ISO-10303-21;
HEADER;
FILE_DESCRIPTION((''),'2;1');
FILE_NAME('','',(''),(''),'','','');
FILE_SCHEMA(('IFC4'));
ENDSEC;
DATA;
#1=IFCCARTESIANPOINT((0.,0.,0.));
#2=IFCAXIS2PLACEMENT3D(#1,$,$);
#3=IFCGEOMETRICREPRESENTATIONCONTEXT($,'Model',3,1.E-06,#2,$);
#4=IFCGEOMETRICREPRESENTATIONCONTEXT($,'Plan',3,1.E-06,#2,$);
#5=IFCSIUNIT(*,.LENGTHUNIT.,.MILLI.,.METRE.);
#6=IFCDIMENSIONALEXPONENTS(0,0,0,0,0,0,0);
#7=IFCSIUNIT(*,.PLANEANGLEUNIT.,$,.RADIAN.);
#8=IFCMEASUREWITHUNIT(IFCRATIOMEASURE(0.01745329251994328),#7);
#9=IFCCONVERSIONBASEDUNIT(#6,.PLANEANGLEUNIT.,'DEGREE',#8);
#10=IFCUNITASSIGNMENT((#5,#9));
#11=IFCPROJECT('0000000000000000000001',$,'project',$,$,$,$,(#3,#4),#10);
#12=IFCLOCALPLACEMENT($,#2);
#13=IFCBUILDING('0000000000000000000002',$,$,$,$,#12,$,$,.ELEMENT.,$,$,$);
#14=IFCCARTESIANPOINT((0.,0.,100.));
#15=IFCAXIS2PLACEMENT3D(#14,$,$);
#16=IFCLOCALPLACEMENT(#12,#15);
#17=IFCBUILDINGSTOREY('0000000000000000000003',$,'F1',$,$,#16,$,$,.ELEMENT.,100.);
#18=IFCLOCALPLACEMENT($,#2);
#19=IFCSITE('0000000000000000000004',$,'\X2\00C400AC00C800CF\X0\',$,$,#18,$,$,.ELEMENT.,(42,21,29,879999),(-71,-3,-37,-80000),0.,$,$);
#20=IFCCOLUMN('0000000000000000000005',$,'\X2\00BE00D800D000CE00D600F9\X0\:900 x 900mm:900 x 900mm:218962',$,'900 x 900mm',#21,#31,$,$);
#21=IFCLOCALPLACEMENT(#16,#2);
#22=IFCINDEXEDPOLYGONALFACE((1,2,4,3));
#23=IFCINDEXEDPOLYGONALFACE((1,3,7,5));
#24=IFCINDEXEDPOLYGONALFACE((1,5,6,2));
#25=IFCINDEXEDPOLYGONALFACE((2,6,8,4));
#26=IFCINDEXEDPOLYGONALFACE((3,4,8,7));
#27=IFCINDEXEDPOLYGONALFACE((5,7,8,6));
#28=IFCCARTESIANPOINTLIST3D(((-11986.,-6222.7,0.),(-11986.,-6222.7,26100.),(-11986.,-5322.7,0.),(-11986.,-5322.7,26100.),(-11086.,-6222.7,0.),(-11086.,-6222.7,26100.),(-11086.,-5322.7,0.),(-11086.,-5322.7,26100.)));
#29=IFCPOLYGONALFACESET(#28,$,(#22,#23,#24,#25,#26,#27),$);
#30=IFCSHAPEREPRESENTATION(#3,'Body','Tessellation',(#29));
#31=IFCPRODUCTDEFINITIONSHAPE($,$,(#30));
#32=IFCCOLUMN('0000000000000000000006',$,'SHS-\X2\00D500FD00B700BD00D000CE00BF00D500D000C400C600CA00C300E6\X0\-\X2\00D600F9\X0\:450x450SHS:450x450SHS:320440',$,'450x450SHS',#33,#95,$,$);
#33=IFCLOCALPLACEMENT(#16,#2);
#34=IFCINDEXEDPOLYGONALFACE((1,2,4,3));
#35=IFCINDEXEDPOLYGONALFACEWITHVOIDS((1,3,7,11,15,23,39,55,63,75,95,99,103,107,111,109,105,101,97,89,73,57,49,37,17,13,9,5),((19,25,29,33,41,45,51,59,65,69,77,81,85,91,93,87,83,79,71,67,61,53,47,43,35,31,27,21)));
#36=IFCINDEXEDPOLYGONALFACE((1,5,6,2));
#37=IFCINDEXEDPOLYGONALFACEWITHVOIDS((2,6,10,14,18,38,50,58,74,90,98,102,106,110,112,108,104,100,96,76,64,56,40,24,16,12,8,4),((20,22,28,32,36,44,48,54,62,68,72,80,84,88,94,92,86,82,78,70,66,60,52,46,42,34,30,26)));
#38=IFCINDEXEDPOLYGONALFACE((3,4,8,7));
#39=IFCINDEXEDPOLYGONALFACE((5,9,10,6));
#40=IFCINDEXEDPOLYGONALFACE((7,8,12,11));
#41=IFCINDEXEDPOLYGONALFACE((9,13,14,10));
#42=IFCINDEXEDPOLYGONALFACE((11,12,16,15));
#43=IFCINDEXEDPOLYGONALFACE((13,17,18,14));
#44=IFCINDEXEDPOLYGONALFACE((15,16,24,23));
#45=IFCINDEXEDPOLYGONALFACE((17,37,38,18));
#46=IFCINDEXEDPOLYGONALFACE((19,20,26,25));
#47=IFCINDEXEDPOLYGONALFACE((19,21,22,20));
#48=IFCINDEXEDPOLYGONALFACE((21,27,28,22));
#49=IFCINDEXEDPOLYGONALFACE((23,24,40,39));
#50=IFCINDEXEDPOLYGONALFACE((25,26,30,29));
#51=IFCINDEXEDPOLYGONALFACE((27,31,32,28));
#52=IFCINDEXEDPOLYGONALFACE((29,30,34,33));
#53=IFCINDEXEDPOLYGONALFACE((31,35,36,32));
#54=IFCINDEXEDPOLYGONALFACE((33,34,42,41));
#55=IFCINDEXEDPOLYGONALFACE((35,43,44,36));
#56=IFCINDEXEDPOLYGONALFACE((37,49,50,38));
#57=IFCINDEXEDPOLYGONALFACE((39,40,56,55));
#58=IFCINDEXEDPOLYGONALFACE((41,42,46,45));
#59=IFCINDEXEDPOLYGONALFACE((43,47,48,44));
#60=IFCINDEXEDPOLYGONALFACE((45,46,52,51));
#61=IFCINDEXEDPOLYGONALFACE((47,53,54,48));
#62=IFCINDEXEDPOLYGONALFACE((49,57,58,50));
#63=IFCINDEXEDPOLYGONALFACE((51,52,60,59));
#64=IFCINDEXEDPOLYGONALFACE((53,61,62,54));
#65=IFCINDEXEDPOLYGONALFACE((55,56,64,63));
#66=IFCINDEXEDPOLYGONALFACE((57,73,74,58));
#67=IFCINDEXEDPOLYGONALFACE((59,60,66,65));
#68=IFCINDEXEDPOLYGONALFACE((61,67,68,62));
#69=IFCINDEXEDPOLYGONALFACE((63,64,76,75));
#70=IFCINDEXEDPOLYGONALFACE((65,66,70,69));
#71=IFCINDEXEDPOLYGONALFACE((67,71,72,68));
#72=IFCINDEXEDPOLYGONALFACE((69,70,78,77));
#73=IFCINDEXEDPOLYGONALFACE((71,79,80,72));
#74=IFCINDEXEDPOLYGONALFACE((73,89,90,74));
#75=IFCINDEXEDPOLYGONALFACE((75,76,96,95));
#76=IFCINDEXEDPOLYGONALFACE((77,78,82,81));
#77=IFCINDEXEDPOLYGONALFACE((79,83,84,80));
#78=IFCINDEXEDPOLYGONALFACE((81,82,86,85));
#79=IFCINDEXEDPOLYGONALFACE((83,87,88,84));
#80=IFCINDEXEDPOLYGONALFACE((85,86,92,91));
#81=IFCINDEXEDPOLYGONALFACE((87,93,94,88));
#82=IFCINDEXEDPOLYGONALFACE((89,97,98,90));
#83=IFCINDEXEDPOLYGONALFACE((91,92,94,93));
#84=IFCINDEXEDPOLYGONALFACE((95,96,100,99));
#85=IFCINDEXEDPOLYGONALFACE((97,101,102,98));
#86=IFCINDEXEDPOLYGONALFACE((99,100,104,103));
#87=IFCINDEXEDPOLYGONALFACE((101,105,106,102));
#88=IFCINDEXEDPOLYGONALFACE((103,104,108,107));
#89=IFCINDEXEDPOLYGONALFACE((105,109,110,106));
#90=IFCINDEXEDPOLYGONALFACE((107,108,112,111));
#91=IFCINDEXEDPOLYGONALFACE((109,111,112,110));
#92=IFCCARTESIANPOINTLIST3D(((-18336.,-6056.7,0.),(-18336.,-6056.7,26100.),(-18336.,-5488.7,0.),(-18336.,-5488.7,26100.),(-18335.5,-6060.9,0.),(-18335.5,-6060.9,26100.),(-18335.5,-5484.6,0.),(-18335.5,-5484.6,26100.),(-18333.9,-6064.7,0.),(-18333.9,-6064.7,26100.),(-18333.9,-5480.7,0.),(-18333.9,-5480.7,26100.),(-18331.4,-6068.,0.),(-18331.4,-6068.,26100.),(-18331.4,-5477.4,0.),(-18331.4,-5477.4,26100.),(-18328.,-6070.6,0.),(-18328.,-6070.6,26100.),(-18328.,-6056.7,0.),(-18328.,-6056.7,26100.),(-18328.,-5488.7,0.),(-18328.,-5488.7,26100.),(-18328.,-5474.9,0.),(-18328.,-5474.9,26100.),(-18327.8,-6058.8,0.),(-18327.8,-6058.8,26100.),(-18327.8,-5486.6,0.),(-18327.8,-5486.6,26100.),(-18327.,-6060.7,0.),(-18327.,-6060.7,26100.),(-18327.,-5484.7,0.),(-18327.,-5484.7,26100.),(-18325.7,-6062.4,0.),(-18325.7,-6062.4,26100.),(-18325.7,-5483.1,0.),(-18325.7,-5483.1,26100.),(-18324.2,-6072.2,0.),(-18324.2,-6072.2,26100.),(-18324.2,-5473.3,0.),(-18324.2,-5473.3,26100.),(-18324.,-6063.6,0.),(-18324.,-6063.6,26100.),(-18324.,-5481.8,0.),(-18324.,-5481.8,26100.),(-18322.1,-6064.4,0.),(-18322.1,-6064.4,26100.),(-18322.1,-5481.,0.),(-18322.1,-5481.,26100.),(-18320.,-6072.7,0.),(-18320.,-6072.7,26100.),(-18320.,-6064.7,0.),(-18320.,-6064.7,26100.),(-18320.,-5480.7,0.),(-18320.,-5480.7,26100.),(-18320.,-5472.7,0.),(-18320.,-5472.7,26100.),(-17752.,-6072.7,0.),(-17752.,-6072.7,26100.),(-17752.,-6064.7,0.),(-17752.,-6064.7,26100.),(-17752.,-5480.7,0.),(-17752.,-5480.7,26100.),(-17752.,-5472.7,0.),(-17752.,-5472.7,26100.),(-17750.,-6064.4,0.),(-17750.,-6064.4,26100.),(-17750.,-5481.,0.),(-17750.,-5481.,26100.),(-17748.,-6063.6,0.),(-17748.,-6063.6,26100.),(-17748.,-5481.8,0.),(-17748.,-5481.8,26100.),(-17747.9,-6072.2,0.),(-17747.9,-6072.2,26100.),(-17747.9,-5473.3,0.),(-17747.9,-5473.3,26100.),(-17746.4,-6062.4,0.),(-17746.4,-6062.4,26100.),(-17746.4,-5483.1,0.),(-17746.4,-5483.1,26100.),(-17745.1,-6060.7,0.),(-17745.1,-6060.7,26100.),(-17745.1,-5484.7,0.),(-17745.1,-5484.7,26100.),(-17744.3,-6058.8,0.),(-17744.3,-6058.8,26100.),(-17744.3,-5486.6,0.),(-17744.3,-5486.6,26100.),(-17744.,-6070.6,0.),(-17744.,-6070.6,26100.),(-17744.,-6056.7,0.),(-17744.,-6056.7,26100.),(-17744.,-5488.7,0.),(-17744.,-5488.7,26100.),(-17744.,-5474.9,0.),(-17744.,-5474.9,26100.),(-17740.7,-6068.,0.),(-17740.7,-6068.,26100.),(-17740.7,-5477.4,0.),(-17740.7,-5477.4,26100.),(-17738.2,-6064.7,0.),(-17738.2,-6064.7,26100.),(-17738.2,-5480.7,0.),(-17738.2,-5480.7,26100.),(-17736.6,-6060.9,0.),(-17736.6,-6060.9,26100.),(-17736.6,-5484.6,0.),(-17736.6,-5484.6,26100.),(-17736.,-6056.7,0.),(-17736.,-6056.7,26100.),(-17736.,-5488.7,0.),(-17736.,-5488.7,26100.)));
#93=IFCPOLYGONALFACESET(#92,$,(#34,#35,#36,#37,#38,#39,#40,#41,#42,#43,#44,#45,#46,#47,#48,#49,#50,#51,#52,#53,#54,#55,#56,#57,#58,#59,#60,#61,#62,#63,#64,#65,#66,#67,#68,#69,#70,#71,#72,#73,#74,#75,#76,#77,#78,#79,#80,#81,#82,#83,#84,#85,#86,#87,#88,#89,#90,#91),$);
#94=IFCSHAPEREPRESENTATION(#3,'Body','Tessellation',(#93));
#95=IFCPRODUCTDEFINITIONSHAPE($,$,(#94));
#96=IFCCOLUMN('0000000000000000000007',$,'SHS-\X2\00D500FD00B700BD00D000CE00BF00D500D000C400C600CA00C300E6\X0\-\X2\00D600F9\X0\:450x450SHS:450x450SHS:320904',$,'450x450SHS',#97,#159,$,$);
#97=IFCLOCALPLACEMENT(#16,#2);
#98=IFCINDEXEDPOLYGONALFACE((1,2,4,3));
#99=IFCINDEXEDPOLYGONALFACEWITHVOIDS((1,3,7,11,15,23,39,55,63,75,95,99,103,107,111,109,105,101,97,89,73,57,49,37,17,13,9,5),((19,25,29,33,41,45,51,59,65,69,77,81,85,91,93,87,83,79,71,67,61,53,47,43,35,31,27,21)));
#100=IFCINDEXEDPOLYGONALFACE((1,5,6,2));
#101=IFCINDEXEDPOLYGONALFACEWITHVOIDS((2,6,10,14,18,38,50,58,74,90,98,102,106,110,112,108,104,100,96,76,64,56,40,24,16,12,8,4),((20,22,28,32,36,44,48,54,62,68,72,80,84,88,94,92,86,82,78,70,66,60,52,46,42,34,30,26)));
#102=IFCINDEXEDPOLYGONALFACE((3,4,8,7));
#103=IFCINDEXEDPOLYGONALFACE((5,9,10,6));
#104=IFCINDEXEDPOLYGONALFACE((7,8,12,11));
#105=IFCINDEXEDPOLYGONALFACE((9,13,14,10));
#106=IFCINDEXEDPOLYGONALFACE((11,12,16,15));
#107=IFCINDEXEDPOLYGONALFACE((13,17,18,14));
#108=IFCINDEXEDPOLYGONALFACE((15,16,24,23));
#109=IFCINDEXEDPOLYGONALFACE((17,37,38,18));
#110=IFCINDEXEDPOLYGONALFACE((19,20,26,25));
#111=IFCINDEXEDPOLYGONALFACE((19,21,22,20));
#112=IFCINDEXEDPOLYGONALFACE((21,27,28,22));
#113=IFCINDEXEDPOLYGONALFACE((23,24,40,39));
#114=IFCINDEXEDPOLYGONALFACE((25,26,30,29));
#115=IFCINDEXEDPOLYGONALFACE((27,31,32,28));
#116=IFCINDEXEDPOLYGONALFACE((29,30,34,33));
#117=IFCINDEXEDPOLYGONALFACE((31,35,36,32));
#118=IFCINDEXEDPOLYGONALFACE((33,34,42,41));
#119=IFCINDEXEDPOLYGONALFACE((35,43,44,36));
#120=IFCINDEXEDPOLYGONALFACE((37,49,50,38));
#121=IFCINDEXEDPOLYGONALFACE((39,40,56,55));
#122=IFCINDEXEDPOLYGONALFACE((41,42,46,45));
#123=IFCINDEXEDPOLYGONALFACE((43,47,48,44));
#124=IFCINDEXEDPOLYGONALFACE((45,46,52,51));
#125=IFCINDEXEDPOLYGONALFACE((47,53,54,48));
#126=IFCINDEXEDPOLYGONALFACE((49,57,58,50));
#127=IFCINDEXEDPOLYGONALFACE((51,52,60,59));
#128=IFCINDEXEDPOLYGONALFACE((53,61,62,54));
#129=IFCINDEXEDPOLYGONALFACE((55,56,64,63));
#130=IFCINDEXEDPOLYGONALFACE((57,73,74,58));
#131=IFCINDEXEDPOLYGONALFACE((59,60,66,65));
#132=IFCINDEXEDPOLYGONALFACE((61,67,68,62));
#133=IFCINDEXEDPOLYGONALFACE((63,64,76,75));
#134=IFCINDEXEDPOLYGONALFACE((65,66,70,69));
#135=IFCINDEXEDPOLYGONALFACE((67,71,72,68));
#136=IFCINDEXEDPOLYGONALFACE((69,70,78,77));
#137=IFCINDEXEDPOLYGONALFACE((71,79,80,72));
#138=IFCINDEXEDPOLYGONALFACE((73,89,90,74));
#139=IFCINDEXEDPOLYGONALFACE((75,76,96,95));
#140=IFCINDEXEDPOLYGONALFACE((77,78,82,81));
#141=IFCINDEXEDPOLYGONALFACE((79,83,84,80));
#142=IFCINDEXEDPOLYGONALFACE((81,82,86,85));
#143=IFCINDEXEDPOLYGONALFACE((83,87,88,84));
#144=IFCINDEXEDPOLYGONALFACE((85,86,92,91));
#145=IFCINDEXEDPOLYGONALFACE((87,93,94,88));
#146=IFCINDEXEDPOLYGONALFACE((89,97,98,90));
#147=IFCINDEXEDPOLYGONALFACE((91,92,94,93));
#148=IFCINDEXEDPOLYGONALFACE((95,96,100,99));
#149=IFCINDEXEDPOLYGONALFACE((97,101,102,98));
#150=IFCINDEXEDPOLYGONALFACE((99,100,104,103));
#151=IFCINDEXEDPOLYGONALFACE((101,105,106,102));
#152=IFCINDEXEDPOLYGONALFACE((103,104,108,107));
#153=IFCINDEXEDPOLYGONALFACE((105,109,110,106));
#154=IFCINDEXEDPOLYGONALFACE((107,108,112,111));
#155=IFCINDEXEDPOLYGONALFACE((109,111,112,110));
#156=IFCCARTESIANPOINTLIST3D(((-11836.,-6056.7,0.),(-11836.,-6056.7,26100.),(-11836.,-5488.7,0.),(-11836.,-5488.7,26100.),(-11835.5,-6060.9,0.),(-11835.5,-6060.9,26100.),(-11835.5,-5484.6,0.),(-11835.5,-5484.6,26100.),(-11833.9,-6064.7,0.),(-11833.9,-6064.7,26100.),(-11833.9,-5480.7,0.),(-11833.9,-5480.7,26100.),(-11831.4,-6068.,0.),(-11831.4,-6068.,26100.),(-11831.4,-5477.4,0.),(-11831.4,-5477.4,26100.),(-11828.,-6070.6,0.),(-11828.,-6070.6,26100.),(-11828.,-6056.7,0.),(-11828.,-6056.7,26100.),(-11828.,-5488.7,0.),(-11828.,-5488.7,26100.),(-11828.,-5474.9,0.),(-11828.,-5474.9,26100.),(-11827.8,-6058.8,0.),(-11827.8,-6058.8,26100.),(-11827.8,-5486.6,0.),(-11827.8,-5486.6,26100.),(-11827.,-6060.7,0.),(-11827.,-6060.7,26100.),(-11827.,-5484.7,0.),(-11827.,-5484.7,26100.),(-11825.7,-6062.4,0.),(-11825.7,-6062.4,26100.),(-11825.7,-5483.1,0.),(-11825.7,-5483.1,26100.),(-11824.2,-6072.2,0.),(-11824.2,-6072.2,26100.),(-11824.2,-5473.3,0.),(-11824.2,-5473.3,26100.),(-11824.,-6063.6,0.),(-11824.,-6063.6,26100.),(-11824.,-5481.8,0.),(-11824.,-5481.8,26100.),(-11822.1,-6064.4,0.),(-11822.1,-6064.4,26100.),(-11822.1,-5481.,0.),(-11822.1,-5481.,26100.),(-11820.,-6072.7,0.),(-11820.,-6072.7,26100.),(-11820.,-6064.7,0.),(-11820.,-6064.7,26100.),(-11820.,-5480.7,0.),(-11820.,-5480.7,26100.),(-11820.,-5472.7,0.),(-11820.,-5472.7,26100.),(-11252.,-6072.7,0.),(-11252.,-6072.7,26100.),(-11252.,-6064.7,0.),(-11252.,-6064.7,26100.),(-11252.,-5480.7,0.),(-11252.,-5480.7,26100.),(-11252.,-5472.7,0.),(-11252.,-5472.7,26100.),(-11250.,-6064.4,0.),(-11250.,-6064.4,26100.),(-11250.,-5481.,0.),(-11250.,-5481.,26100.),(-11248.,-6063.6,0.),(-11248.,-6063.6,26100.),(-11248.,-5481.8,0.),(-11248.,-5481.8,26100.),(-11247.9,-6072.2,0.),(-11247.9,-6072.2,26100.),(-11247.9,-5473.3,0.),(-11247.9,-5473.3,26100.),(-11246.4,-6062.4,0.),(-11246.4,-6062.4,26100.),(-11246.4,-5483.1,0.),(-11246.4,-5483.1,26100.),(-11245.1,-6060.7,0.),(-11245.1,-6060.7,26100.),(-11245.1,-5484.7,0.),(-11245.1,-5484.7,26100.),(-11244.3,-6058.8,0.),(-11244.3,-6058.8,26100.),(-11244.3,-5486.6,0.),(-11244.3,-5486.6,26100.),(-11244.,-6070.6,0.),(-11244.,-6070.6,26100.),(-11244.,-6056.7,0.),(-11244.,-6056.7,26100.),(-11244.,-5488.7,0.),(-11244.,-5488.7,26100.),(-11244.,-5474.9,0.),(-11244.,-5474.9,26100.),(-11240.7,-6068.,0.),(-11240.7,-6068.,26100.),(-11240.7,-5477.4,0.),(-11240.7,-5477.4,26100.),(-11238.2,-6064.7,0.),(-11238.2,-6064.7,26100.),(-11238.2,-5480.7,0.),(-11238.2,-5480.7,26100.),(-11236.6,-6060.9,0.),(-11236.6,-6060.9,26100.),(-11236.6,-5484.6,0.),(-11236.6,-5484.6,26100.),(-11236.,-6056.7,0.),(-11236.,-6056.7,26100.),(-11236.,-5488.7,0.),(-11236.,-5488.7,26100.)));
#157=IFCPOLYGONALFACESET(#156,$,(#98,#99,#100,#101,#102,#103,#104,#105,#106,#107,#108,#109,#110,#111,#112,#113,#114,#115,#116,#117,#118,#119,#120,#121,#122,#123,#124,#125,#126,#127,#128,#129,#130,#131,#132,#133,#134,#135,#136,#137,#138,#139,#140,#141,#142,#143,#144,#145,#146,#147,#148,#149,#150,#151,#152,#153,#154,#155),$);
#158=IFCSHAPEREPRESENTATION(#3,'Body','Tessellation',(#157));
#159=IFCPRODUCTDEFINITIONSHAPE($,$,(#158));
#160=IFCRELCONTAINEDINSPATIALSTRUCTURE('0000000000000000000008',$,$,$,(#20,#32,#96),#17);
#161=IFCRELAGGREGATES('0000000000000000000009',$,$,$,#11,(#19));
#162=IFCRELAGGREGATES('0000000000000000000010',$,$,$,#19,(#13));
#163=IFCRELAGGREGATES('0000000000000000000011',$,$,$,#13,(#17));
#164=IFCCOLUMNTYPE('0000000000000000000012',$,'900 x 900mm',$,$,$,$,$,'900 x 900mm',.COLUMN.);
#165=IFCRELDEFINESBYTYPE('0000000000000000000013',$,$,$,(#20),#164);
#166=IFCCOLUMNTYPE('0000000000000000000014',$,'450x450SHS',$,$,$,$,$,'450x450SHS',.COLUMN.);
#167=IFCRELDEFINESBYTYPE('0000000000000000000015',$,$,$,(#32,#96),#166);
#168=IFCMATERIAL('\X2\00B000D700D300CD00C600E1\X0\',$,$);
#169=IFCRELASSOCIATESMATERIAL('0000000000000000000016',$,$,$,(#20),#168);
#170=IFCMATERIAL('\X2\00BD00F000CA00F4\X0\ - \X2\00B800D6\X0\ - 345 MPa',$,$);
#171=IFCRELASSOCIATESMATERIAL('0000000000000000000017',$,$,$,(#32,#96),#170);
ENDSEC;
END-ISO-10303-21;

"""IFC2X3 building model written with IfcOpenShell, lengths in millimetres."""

from ifc_helpers import new_model, entity, si_unit, converted_unit, frame, frame_2d, origin, place, context, project, spatial, polyline, circle_curve, parameter, trimmed, segment, composite_curve, rectangle, outline, extrude, source, transform, mapped, material, type_object, type_shapes, element, save


model = new_model("IFC2X3")

# Units and contexts
model_context = context("Model", 3, precision=1e-06, world=origin())
plan_context = context("Plan", 3, precision=1e-06, world=origin())
ifc_project = project(units=[si_unit("LENGTHUNIT", "METRE", prefix="MILLI"), converted_unit("PLANEANGLEUNIT", "DEGREE", entity("IfcRatioMeasure", 0.01745329251994328), si_unit("PLANEANGLEUNIT", "RADIAN"), dimensions=[0, 0, 0, 0, 0, 0, 0])], contexts=[model_context, plan_context])

# Site, building, storey
site_placement = place(None, origin())
site = spatial("IfcSite", under=ifc_project, at=site_placement, Name="Ä¬ÈÏ", CompositionType="ELEMENT", RefLatitude=(42, 21, 29, 879999), RefLongitude=(-71, -3, -37, -80000), RefElevation=0.0)
building_placement = place(None, origin())
building = spatial("IfcBuilding", under=site, at=building_placement, CompositionType="ELEMENT")
storey_placement = place(building_placement, frame((0.0, 0.0, 100.0)))
storey = spatial("IfcBuildingStorey", under=building, at=storey_placement, Name="F1", CompositionType="ELEMENT", Elevation=100.0)

# Columns
ifc_material_1 = material(Name="°×ÓÍÆá")
column_type_1 = type_object("IfcColumnType", Name="900 x 900mm", ElementType="900 x 900mm", PredefinedType="COLUMN")
shared_shape_1 = source(origin(), model_context, "Body", "SweptSolid", [
    extrude(rectangle(XDim=900.0, YDim=900.0, at=frame_2d((0.0, 0.0), x_axis=(0.0, -1.0))), origin(), (0.0, 0.0, 1.0), 26100.0),
])
type_shapes(column_type_1, [shared_shape_1])
column_placement = place(storey_placement, frame((-11536.0, -5772.7, 0.0)))
element("IfcColumn", 1, at=column_placement, inside=storey, type_object=column_type_1, material=ifc_material_1, Name="¾ØÐÎÖù:900 x 900mm:900 x 900mm:218962", ObjectType="900 x 900mm", context=model_context, shape_type="MappedRepresentation", body=[
    mapped(shared_shape_1, transform((0.0, 0.0, 0.0), scale=1.0)),
])
ifc_material_2 = material(Name="½ðÊô - ¸Ö - 345 MPa")
column_type_2 = type_object("IfcColumnType", Name="450x450SHS", ElementType="450x450SHS", PredefinedType="COLUMN")
shared_shape_2 = source(origin(), model_context, "Body", "SweptSolid", [
    extrude(outline(composite_curve([segment(polyline([(-284.0, -300.0), (284.0, -300.0)]), True, "CONTINUOUS"), segment(trimmed(circle_curve(frame_2d((284.0, -284.0), x_axis=(-1.0, 0.0)), 16.0), [parameter(90.0)], [parameter(180.0)], True, "PARAMETER"), True, "CONTINUOUS"), segment(polyline([(300.0, -284.0), (300.0, 284.0)]), True, "CONTINUOUS"), segment(trimmed(circle_curve(frame_2d((284.0, 284.0), x_axis=(-1.0, 0.0)), 16.0), [parameter(180.0)], [parameter(270.0)], True, "PARAMETER"), True, "CONTINUOUS"), segment(polyline([(284.0, 300.0), (-284.0, 300.0)]), True, "CONTINUOUS"), segment(trimmed(circle_curve(frame_2d((-284.0, 284.0), x_axis=(-1.0, 0.0)), 16.0), [parameter(270.0)], [parameter(360.0)], True, "PARAMETER"), True, "CONTINUOUS"), segment(polyline([(-300.0, 284.0), (-300.0, -284.0)]), True, "CONTINUOUS"), segment(trimmed(circle_curve(frame_2d((-284.0, -284.0), x_axis=(-1.0, 0.0)), 16.0), [parameter(360.0)], [parameter(90.0)], True, "PARAMETER"), True, "CONTINUOUS")], self_intersect=False), holes=[composite_curve([segment(trimmed(circle_curve(frame_2d((-284.0, -284.0), x_axis=(-1.0, 0.0)), 8.0), [parameter(0.0)], [parameter(90.0)], True, "PARAMETER"), False, "CONTINUOUS"), segment(polyline([(-292.0, -284.0), (-292.0, 284.0)]), True, "CONTINUOUS"), segment(trimmed(circle_curve(frame_2d((-284.0, 284.0), x_axis=(-1.0, 0.0)), 8.0), [parameter(270.0)], [parameter(360.0)], True, "PARAMETER"), False, "CONTINUOUS"), segment(polyline([(-284.0, 292.0), (284.0, 292.0)]), True, "CONTINUOUS"), segment(trimmed(circle_curve(frame_2d((284.0, 284.0), x_axis=(-1.0, 0.0)), 8.0), [parameter(180.0)], [parameter(270.0)], True, "PARAMETER"), False, "CONTINUOUS"), segment(polyline([(292.0, 284.0), (292.0, -284.0)]), True, "CONTINUOUS"), segment(trimmed(circle_curve(frame_2d((284.0, -284.0), x_axis=(-1.0, 0.0)), 8.0), [parameter(90.0)], [parameter(180.0)], True, "PARAMETER"), False, "CONTINUOUS"), segment(polyline([(284.0, -292.0), (-284.0, -292.0)]), True, "CONTINUOUS")], self_intersect=False)]), frame((0.0, 0.0, 100.0), z_axis=(0.0, 0.0, 1.0), x_axis=(-1.0, 0.0, 0.0)), (0.0, 0.0, 1.0), 26100.0),
])
type_shapes(column_type_2, [shared_shape_2])
for number, where, name in (
    (2, (-18036.0, -5772.7, -100.0), "SHS-Õý·½ÐÎ¿ÕÐÄÆÊÃæ-Öù:450x450SHS:450x450SHS:320440"),
    (3, (-11536.0, -5772.7, -100.0), "SHS-Õý·½ÐÎ¿ÕÐÄÆÊÃæ-Öù:450x450SHS:450x450SHS:320904"),
):
    element("IfcColumn", number, at=place(storey_placement, frame(where)), inside=storey, type_object=column_type_2, material=ifc_material_2, Name=name, ObjectType="450x450SHS", context=model_context, shape_type="MappedRepresentation", body=[
        mapped(shared_shape_2, transform((0.0, 0.0, 0.0), scale=1.0)),
    ])

save(model, "model.ifc")
